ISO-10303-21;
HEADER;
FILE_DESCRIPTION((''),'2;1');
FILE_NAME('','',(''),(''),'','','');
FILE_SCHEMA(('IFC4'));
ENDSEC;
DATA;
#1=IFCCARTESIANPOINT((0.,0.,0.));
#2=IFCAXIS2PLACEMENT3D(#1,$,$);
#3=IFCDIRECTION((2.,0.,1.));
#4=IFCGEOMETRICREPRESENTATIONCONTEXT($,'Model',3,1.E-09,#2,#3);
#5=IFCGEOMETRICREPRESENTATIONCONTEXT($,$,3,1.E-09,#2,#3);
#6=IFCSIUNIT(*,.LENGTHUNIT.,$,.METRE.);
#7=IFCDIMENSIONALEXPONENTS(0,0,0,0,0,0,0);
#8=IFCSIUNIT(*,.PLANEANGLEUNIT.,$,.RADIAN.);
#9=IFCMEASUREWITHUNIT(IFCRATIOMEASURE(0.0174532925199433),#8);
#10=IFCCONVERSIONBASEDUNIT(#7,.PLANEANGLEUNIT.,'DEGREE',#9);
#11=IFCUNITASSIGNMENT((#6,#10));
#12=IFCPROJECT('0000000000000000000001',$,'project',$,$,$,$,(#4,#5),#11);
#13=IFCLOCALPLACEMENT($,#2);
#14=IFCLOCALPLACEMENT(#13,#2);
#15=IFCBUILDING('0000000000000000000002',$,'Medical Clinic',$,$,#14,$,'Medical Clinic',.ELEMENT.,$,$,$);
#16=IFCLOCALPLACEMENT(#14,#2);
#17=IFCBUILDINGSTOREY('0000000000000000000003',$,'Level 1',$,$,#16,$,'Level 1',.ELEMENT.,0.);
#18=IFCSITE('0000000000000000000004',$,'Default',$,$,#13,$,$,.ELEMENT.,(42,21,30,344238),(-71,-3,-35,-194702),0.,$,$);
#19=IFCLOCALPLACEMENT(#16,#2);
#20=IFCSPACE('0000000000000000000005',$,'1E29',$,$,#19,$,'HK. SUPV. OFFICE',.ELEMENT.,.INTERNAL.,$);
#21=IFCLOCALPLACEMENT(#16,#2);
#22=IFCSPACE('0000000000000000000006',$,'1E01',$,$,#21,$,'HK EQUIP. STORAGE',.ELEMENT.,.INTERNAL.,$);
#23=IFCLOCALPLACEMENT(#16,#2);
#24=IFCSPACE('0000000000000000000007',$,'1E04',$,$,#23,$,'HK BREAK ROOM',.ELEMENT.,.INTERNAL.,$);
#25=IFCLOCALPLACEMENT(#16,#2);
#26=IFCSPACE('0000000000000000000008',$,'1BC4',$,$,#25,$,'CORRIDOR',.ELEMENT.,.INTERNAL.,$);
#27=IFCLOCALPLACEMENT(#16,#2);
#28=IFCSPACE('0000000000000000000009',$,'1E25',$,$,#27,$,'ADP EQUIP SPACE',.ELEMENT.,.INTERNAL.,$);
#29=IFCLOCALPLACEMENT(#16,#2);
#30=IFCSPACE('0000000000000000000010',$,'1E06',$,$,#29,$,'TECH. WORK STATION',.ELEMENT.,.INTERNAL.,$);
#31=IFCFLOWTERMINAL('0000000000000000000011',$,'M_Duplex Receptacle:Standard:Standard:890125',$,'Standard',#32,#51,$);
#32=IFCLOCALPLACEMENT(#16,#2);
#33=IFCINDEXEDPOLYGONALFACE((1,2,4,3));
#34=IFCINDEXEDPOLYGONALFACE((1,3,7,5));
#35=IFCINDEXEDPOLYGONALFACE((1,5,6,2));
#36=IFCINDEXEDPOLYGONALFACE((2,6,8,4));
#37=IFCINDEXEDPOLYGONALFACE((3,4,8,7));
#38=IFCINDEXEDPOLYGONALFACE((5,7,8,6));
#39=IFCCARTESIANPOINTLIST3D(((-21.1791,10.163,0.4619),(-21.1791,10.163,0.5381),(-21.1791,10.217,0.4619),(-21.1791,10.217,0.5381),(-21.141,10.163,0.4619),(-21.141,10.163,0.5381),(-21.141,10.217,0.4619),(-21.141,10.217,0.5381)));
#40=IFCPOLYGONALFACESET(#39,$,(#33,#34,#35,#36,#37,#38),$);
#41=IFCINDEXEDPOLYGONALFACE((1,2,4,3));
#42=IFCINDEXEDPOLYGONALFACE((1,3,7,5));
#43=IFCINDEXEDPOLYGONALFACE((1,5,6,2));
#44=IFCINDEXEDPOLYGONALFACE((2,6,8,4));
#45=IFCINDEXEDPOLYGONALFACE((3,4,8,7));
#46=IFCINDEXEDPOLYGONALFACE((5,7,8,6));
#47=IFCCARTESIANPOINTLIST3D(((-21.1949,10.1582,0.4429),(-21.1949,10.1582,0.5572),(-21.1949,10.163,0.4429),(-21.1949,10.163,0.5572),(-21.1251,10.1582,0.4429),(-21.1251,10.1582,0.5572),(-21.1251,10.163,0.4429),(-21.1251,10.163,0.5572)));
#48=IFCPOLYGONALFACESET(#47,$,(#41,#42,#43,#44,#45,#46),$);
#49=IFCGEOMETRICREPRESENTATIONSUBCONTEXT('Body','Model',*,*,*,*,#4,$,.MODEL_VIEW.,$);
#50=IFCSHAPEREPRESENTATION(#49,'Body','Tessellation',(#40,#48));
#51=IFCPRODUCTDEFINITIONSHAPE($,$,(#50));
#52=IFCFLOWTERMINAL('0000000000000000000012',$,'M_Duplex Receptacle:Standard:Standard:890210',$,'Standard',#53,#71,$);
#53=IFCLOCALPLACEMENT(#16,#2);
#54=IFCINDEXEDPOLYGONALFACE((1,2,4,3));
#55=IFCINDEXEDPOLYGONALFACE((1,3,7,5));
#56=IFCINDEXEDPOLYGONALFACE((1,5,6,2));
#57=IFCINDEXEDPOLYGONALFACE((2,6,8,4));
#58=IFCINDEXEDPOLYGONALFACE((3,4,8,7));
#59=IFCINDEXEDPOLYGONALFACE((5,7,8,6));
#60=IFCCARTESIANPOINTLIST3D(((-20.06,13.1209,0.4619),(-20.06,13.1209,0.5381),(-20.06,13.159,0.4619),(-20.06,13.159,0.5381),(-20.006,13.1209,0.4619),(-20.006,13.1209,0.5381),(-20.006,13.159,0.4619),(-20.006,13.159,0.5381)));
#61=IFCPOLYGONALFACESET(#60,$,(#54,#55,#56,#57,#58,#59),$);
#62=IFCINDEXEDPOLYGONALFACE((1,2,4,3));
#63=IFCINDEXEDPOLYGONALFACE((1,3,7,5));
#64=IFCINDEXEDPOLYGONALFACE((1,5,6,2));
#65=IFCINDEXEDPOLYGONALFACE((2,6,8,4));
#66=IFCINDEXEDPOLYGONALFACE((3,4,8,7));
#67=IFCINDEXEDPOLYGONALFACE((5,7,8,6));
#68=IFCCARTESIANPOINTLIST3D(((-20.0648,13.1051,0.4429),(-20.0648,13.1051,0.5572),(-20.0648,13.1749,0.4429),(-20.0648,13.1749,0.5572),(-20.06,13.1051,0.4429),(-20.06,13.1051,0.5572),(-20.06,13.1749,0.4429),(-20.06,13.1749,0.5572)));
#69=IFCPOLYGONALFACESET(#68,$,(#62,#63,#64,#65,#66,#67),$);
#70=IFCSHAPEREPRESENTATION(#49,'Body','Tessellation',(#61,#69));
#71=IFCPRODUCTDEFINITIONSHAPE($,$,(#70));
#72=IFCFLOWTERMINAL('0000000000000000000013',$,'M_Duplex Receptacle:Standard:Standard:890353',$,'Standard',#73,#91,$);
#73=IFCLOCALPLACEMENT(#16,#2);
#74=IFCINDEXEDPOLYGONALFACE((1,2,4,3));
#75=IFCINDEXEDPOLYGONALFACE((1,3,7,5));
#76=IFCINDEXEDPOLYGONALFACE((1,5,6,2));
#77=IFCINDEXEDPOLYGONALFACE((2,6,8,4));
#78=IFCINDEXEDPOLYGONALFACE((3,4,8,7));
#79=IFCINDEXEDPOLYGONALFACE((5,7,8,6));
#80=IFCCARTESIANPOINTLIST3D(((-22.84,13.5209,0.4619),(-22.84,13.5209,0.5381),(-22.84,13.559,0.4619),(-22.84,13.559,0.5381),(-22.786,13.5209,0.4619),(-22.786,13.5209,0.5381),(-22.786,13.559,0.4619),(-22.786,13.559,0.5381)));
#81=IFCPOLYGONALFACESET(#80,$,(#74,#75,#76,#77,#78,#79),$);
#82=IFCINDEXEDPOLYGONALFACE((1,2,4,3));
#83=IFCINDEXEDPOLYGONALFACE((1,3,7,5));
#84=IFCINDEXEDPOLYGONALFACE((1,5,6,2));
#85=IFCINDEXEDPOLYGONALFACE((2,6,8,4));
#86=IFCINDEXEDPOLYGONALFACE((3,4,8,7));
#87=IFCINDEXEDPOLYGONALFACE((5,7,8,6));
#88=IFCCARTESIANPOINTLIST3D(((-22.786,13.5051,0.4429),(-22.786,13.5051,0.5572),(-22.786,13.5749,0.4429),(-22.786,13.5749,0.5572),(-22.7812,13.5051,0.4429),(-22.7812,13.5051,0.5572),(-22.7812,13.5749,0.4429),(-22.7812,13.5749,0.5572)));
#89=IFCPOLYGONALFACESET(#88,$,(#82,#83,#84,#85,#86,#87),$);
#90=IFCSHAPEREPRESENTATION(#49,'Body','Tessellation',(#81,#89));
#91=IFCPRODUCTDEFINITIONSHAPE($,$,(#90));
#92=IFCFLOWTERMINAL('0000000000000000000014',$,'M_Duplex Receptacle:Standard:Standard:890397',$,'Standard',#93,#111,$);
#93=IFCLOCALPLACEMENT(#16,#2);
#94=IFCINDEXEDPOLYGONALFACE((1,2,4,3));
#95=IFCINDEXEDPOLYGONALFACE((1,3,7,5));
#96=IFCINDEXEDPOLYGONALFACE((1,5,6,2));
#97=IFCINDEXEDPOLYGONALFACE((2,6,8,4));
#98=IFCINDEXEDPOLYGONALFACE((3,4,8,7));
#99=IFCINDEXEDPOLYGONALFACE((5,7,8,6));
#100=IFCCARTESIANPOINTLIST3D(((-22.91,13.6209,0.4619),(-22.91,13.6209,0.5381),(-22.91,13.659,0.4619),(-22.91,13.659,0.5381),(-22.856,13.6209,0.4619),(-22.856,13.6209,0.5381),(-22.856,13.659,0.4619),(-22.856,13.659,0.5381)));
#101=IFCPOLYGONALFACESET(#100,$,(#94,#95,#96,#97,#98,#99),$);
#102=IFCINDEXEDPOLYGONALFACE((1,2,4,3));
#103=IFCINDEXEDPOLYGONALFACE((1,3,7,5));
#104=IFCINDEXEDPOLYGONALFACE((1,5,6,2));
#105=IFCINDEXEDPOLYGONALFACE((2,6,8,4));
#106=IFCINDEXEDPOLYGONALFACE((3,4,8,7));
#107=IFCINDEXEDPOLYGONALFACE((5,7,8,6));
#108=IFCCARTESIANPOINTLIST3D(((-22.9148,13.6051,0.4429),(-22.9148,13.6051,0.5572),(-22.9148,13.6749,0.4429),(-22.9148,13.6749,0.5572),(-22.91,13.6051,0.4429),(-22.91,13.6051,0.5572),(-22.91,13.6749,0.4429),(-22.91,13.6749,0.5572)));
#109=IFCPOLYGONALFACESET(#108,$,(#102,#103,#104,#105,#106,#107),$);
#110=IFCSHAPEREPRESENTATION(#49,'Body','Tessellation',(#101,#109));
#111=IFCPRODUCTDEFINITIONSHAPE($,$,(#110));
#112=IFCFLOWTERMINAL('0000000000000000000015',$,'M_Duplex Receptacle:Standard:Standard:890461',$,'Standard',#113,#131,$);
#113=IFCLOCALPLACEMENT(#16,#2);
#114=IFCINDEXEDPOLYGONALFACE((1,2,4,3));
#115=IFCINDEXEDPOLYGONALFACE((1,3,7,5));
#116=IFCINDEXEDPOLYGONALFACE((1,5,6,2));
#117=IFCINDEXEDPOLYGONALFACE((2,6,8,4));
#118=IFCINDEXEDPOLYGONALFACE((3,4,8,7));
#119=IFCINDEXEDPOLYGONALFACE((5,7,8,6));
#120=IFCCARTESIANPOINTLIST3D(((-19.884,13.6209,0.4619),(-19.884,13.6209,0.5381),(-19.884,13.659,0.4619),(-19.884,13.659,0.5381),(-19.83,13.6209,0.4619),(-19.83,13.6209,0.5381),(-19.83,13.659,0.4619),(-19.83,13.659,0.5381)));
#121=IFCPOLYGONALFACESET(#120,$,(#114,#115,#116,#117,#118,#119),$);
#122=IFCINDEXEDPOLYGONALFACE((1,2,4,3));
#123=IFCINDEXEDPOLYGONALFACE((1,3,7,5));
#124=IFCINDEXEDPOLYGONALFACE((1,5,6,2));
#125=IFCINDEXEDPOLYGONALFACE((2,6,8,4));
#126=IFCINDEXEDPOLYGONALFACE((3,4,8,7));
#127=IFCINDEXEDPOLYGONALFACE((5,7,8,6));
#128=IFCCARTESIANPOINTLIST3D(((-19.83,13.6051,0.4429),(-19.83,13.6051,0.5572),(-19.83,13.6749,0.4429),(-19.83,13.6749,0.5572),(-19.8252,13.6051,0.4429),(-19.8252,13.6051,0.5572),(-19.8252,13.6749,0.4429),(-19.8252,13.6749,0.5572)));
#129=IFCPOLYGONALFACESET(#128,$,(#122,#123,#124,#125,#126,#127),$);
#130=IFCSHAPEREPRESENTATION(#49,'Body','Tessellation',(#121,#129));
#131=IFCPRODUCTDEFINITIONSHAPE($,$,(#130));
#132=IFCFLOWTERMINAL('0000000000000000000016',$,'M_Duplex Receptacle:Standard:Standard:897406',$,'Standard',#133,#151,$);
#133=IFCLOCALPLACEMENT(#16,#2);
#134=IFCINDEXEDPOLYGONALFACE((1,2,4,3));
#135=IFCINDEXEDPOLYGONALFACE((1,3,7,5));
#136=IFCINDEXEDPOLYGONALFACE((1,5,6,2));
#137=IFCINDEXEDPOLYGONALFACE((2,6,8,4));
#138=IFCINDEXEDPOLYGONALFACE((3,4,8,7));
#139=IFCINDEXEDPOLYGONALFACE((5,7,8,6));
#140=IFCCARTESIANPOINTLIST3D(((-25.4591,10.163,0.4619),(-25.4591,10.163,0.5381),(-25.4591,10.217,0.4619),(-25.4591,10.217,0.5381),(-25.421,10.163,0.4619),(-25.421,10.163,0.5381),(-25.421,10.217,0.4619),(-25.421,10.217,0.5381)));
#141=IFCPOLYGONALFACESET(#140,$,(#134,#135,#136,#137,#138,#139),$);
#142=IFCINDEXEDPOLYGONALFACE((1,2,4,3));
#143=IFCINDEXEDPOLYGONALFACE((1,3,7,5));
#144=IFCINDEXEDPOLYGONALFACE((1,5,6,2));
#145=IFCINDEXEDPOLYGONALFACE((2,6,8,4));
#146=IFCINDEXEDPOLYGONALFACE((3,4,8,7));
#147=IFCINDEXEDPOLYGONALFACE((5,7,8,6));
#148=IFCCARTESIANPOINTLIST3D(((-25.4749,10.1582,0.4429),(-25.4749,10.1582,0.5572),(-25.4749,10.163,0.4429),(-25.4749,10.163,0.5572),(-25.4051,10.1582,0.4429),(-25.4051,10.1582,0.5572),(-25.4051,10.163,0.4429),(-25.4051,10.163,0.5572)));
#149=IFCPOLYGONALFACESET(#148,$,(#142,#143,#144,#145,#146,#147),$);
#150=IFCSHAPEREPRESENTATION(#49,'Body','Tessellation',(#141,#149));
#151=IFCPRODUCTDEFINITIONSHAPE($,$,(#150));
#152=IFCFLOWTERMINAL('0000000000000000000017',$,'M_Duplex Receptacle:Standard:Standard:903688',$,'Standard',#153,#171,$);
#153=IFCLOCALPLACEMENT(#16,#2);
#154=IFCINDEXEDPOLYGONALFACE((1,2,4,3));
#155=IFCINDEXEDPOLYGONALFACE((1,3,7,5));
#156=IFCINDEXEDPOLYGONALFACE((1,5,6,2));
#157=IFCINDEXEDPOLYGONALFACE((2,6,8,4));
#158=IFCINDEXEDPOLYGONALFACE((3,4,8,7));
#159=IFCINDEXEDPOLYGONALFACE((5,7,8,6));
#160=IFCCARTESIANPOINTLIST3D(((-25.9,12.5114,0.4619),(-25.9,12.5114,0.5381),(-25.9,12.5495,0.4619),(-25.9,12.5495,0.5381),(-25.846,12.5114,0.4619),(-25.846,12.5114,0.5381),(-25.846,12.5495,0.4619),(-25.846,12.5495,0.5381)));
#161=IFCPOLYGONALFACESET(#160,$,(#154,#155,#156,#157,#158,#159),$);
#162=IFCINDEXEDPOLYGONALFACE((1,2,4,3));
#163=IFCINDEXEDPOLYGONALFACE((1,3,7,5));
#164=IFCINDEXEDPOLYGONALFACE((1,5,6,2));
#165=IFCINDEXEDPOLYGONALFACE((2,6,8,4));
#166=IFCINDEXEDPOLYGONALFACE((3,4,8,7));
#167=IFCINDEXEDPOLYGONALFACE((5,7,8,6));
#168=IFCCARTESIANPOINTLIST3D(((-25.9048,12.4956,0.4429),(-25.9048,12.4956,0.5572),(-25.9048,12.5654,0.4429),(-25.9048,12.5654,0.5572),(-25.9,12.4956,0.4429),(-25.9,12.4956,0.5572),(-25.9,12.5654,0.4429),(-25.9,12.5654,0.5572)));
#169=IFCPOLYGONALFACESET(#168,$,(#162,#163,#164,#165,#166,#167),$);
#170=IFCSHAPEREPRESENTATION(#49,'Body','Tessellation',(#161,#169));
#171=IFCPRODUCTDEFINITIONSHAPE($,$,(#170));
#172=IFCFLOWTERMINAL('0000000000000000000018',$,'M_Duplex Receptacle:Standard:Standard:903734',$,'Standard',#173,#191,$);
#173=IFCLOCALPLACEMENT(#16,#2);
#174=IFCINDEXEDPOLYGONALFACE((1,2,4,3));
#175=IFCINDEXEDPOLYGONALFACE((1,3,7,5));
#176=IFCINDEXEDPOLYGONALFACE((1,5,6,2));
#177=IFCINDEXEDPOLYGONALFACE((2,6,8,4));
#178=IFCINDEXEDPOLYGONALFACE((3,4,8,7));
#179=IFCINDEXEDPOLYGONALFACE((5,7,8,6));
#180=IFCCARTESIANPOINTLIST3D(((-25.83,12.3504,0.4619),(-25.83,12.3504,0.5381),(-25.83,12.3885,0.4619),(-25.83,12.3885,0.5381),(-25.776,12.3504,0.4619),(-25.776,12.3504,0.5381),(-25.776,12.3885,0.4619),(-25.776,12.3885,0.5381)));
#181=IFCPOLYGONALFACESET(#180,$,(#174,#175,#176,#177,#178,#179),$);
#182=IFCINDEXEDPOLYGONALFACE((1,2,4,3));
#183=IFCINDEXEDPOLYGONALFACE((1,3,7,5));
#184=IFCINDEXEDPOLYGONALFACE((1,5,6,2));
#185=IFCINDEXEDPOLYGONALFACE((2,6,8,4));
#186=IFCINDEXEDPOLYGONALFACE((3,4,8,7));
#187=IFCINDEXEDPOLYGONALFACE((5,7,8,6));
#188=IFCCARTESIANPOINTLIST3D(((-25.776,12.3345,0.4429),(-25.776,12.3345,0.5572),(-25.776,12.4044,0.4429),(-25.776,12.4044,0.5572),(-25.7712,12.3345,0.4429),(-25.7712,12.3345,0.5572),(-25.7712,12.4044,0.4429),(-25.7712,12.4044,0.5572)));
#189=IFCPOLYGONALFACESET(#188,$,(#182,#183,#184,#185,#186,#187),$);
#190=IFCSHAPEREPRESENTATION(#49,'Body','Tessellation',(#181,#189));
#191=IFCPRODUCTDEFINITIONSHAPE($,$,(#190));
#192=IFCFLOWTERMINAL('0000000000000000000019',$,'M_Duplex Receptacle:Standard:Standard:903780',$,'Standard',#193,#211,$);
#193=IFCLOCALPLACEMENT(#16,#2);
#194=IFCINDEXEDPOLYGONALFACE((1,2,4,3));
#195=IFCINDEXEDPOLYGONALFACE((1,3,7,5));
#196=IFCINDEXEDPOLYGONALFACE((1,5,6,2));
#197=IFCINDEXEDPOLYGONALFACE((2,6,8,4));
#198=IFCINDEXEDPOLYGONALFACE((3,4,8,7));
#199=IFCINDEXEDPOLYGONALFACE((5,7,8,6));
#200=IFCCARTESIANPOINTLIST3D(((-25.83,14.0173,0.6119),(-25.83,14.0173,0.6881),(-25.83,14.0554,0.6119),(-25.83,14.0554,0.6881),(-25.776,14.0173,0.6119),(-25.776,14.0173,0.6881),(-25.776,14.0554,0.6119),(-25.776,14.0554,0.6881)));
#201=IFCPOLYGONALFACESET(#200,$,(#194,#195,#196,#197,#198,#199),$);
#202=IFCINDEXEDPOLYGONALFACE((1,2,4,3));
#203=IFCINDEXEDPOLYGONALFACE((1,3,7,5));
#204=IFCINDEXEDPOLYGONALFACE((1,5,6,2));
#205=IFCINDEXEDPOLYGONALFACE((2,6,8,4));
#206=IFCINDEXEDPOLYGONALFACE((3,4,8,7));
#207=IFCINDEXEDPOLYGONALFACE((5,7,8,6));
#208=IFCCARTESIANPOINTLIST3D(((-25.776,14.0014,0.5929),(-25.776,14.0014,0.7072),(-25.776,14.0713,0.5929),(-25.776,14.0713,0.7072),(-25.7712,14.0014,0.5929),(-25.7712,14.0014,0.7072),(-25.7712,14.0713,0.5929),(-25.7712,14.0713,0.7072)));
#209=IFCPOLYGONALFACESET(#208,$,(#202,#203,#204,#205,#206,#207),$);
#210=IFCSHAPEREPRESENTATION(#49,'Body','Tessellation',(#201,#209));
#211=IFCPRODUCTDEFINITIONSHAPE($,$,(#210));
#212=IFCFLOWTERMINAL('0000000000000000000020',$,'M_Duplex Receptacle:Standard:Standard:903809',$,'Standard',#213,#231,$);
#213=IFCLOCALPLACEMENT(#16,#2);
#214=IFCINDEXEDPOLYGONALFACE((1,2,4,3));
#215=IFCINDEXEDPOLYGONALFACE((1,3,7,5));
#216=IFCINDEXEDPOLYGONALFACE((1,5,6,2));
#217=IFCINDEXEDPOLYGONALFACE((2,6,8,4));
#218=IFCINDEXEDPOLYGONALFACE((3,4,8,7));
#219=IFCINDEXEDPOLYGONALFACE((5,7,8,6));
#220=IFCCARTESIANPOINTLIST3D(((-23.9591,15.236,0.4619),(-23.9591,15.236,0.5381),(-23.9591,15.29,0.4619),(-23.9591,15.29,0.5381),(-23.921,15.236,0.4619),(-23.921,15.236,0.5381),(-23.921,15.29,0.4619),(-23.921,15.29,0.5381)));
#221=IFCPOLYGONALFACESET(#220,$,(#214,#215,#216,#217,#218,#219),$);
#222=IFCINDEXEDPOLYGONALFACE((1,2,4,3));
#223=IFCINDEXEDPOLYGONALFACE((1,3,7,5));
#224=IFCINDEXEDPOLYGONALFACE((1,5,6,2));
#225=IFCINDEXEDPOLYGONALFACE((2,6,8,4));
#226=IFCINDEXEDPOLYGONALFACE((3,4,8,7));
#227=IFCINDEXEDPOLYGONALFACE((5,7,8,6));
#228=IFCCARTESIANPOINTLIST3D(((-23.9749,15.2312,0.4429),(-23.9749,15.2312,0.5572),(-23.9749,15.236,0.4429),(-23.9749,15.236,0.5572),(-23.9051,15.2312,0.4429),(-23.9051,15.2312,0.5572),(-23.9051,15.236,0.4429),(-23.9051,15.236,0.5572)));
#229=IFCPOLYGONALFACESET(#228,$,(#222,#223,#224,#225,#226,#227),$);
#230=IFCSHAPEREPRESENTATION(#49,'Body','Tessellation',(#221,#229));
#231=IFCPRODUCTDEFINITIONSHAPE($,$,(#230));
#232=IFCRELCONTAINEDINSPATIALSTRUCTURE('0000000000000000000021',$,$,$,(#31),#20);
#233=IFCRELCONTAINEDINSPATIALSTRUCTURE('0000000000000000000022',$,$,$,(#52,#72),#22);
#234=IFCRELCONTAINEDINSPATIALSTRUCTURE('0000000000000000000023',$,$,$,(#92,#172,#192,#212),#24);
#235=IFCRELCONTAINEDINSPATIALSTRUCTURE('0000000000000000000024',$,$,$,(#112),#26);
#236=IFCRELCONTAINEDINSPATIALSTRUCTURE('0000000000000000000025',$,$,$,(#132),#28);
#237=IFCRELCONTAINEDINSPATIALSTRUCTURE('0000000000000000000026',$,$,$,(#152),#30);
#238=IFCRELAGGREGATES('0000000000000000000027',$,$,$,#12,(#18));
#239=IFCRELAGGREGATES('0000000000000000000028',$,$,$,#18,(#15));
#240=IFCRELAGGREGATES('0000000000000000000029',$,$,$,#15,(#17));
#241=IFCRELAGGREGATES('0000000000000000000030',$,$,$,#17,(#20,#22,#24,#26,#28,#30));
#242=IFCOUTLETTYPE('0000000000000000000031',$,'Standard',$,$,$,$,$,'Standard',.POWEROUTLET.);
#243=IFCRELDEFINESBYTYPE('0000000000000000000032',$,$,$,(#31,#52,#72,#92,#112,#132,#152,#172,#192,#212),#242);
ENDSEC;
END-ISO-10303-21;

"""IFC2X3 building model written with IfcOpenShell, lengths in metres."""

from ifc_helpers import new_model, entity, si_unit, converted_unit, direction, frame, frame_2d, origin, origin_2d_with_axis, place, context, subcontext, project, spatial, rectangle, extrude, source, transform, mapped, type_object, type_shapes, element, save


model = new_model("IFC2X3")

# Units and contexts
model_context = context("Model", 3, precision=1e-09, world=origin(), true_north=direction((2.0, 0.0, 1.0)))
context_of_model = context(None, 3, precision=1e-09, world=origin(), true_north=direction((2.0, 0.0, 1.0)))
body_context = subcontext(model_context, "Body", "Model", "MODEL_VIEW")
ifc_project = project(units=[si_unit("LENGTHUNIT", "METRE"), converted_unit("PLANEANGLEUNIT", "DEGREE", entity("IfcRatioMeasure", 0.0174532925199433), si_unit("PLANEANGLEUNIT", "RADIAN"), dimensions=[0, 0, 0, 0, 0, 0, 0])], contexts=[model_context, context_of_model])

# Site, building, storey, space
site_placement = place(None, origin())
site = spatial("IfcSite", under=ifc_project, at=site_placement, Name="Default", CompositionType="ELEMENT", RefLatitude=(42, 21, 30, 344238), RefLongitude=(-71, -3, -35, -194702), RefElevation=0.0)
building_placement = place(site_placement, origin())
building = spatial("IfcBuilding", under=site, at=building_placement, Name="Medical Clinic", LongName="Medical Clinic", CompositionType="ELEMENT")
storey_placement = place(building_placement, origin())
storey = spatial("IfcBuildingStorey", under=building, at=storey_placement, Name="Level 1", LongName="Level 1", CompositionType="ELEMENT", Elevation=0.0)
space_1_placement = place(storey_placement, origin())
space_1 = spatial("IfcSpace", under=storey, at=space_1_placement, Name="1E29", LongName="HK. SUPV. OFFICE", CompositionType="ELEMENT", InteriorOrExteriorSpace="INTERNAL")

# Flow terminal
outlet_type = type_object("IfcOutletType", Name="Standard", ElementType="Standard", PredefinedType="POWEROUTLET")
shared_shape_1 = source(origin(), body_context, "Body", "SweptSolid", [
    extrude(rectangle(XDim=0.0381, YDim=0.0762, at=origin_2d_with_axis()), frame((0.0, 0.0, -0.054), z_axis=(0.0, 0.0, 1.0), x_axis=(-1.0, 0.0, 0.0)), (0.0, 0.0, 1.0), 0.054),
    extrude(rectangle(XDim=0.0698, YDim=0.1143, at=frame_2d((0.0, 0.0), x_axis=(1.0, 0.0))), frame((0.0, 0.0, 0.0), z_axis=(0.0, 0.0, 1.0), x_axis=(-1.0, 0.0, 0.0)), (0.0, 0.0, 1.0), 0.0048),
])
type_shapes(outlet_type, [shared_shape_1])
flow_terminal_1_placement = place(space_1_placement, frame((-21.16, 10.163, 0.5), z_axis=(0.0, -1.0, 0.0), x_axis=(1.0, 0.0, 0.0)))
element("IfcFlowTerminal", 1, at=flow_terminal_1_placement, inside=space_1, type_object=outlet_type, Name="M_Duplex Receptacle:Standard:Standard:890125", ObjectType="Standard", context=body_context, shape_type="MappedRepresentation", body=[
    mapped(shared_shape_1, transform((0.0, 0.0, 0.0), scale=1.0)),
])

# Shared definitions
space_2_placement = place(storey_placement, origin())
space_2 = spatial("IfcSpace", under=storey, at=space_2_placement, Name="1E01", LongName="HK EQUIP. STORAGE", CompositionType="ELEMENT", InteriorOrExteriorSpace="INTERNAL")

# Flow terminals
for number, where, z_axis, x_axis, name in (
    (2, (-20.06, 13.14, 0.5), (-1.0, 0.0, 0.0), (0.0, -1.0, 0.0), "M_Duplex Receptacle:Standard:Standard:890210"),
    (3, (-22.786, 13.54, 0.5), (1.0, 0.0, 0.0), (0.0, 1.0, 0.0), "M_Duplex Receptacle:Standard:Standard:890353"),
):
    element("IfcFlowTerminal", number, at=place(space_2_placement, frame(where, z_axis=z_axis, x_axis=x_axis)), inside=space_2, type_object=outlet_type, Name=name, ObjectType="Standard", context=body_context, shape_type="MappedRepresentation", body=[
        mapped(shared_shape_1, transform((0.0, 0.0, 0.0), scale=1.0)),
    ])

# Shared definitions
space_3_placement = place(storey_placement, origin())
space_3 = spatial("IfcSpace", under=storey, at=space_3_placement, Name="1E04", LongName="HK BREAK ROOM", CompositionType="ELEMENT", InteriorOrExteriorSpace="INTERNAL")

# Flow terminal
flow_terminal_2_placement = place(space_3_placement, frame((-22.91, 13.64, 0.5), z_axis=(-1.0, 0.0, 0.0), x_axis=(0.0, -1.0, 0.0)))
element("IfcFlowTerminal", 4, at=flow_terminal_2_placement, inside=space_3, type_object=outlet_type, Name="M_Duplex Receptacle:Standard:Standard:890397", ObjectType="Standard", context=body_context, shape_type="MappedRepresentation", body=[
    mapped(shared_shape_1, transform((0.0, 0.0, 0.0), scale=1.0)),
])

# Shared definitions
space_4_placement = place(storey_placement, origin())
space_4 = spatial("IfcSpace", under=storey, at=space_4_placement, Name="1BC4", LongName="CORRIDOR", CompositionType="ELEMENT", InteriorOrExteriorSpace="INTERNAL")

# Flow terminal
flow_terminal_3_placement = place(space_4_placement, frame((-19.83, 13.64, 0.5), z_axis=(1.0, 0.0, 0.0), x_axis=(0.0, 1.0, 0.0)))
element("IfcFlowTerminal", 5, at=flow_terminal_3_placement, inside=space_4, type_object=outlet_type, Name="M_Duplex Receptacle:Standard:Standard:890461", ObjectType="Standard", context=body_context, shape_type="MappedRepresentation", body=[
    mapped(shared_shape_1, transform((0.0, 0.0, 0.0), scale=1.0)),
])

# Shared definitions
space_5_placement = place(storey_placement, origin())
space_5 = spatial("IfcSpace", under=storey, at=space_5_placement, Name="1E25", LongName="ADP EQUIP SPACE", CompositionType="ELEMENT", InteriorOrExteriorSpace="INTERNAL")

# Flow terminal
flow_terminal_4_placement = place(space_5_placement, frame((-25.44, 10.163, 0.5), z_axis=(0.0, -1.0, 0.0), x_axis=(1.0, 0.0, 0.0)))
element("IfcFlowTerminal", 6, at=flow_terminal_4_placement, inside=space_5, type_object=outlet_type, Name="M_Duplex Receptacle:Standard:Standard:897406", ObjectType="Standard", context=body_context, shape_type="MappedRepresentation", body=[
    mapped(shared_shape_1, transform((0.0, 0.0, 0.0), scale=1.0)),
])

# Shared definitions
space_6_placement = place(storey_placement, origin())
space_6 = spatial("IfcSpace", under=storey, at=space_6_placement, Name="1E06", LongName="TECH. WORK STATION", CompositionType="ELEMENT", InteriorOrExteriorSpace="INTERNAL")

# Flow terminals
flow_terminal_5_placement = place(space_6_placement, frame((-25.9, 12.5305, 0.5), z_axis=(-1.0, 0.0, 0.0), x_axis=(0.0, -1.0, 0.0)))
element("IfcFlowTerminal", 7, at=flow_terminal_5_placement, inside=space_6, type_object=outlet_type, Name="M_Duplex Receptacle:Standard:Standard:903688", ObjectType="Standard", context=body_context, shape_type="MappedRepresentation", body=[
    mapped(shared_shape_1, transform((0.0, 0.0, 0.0), scale=1.0)),
])
for number, where, z_axis, x_axis, name in (
    (8, (-25.776, 12.3694, 0.5), (1.0, 0.0, 0.0), (0.0, 1.0, 0.0), "M_Duplex Receptacle:Standard:Standard:903734"),
    (9, (-25.776, 14.0363, 0.65), (1.0, 0.0, 0.0), (0.0, 1.0, 0.0), "M_Duplex Receptacle:Standard:Standard:903780"),
    (10, (-23.94, 15.236, 0.5), (0.0, -1.0, 0.0), (1.0, 0.0, 0.0), "M_Duplex Receptacle:Standard:Standard:903809"),
):
    element("IfcFlowTerminal", number, at=place(space_3_placement, frame(where, z_axis=z_axis, x_axis=x_axis)), inside=space_3, type_object=outlet_type, Name=name, ObjectType="Standard", context=body_context, shape_type="MappedRepresentation", body=[
        mapped(shared_shape_1, transform((0.0, 0.0, 0.0), scale=1.0)),
    ])

save(model, "model.ifc")
